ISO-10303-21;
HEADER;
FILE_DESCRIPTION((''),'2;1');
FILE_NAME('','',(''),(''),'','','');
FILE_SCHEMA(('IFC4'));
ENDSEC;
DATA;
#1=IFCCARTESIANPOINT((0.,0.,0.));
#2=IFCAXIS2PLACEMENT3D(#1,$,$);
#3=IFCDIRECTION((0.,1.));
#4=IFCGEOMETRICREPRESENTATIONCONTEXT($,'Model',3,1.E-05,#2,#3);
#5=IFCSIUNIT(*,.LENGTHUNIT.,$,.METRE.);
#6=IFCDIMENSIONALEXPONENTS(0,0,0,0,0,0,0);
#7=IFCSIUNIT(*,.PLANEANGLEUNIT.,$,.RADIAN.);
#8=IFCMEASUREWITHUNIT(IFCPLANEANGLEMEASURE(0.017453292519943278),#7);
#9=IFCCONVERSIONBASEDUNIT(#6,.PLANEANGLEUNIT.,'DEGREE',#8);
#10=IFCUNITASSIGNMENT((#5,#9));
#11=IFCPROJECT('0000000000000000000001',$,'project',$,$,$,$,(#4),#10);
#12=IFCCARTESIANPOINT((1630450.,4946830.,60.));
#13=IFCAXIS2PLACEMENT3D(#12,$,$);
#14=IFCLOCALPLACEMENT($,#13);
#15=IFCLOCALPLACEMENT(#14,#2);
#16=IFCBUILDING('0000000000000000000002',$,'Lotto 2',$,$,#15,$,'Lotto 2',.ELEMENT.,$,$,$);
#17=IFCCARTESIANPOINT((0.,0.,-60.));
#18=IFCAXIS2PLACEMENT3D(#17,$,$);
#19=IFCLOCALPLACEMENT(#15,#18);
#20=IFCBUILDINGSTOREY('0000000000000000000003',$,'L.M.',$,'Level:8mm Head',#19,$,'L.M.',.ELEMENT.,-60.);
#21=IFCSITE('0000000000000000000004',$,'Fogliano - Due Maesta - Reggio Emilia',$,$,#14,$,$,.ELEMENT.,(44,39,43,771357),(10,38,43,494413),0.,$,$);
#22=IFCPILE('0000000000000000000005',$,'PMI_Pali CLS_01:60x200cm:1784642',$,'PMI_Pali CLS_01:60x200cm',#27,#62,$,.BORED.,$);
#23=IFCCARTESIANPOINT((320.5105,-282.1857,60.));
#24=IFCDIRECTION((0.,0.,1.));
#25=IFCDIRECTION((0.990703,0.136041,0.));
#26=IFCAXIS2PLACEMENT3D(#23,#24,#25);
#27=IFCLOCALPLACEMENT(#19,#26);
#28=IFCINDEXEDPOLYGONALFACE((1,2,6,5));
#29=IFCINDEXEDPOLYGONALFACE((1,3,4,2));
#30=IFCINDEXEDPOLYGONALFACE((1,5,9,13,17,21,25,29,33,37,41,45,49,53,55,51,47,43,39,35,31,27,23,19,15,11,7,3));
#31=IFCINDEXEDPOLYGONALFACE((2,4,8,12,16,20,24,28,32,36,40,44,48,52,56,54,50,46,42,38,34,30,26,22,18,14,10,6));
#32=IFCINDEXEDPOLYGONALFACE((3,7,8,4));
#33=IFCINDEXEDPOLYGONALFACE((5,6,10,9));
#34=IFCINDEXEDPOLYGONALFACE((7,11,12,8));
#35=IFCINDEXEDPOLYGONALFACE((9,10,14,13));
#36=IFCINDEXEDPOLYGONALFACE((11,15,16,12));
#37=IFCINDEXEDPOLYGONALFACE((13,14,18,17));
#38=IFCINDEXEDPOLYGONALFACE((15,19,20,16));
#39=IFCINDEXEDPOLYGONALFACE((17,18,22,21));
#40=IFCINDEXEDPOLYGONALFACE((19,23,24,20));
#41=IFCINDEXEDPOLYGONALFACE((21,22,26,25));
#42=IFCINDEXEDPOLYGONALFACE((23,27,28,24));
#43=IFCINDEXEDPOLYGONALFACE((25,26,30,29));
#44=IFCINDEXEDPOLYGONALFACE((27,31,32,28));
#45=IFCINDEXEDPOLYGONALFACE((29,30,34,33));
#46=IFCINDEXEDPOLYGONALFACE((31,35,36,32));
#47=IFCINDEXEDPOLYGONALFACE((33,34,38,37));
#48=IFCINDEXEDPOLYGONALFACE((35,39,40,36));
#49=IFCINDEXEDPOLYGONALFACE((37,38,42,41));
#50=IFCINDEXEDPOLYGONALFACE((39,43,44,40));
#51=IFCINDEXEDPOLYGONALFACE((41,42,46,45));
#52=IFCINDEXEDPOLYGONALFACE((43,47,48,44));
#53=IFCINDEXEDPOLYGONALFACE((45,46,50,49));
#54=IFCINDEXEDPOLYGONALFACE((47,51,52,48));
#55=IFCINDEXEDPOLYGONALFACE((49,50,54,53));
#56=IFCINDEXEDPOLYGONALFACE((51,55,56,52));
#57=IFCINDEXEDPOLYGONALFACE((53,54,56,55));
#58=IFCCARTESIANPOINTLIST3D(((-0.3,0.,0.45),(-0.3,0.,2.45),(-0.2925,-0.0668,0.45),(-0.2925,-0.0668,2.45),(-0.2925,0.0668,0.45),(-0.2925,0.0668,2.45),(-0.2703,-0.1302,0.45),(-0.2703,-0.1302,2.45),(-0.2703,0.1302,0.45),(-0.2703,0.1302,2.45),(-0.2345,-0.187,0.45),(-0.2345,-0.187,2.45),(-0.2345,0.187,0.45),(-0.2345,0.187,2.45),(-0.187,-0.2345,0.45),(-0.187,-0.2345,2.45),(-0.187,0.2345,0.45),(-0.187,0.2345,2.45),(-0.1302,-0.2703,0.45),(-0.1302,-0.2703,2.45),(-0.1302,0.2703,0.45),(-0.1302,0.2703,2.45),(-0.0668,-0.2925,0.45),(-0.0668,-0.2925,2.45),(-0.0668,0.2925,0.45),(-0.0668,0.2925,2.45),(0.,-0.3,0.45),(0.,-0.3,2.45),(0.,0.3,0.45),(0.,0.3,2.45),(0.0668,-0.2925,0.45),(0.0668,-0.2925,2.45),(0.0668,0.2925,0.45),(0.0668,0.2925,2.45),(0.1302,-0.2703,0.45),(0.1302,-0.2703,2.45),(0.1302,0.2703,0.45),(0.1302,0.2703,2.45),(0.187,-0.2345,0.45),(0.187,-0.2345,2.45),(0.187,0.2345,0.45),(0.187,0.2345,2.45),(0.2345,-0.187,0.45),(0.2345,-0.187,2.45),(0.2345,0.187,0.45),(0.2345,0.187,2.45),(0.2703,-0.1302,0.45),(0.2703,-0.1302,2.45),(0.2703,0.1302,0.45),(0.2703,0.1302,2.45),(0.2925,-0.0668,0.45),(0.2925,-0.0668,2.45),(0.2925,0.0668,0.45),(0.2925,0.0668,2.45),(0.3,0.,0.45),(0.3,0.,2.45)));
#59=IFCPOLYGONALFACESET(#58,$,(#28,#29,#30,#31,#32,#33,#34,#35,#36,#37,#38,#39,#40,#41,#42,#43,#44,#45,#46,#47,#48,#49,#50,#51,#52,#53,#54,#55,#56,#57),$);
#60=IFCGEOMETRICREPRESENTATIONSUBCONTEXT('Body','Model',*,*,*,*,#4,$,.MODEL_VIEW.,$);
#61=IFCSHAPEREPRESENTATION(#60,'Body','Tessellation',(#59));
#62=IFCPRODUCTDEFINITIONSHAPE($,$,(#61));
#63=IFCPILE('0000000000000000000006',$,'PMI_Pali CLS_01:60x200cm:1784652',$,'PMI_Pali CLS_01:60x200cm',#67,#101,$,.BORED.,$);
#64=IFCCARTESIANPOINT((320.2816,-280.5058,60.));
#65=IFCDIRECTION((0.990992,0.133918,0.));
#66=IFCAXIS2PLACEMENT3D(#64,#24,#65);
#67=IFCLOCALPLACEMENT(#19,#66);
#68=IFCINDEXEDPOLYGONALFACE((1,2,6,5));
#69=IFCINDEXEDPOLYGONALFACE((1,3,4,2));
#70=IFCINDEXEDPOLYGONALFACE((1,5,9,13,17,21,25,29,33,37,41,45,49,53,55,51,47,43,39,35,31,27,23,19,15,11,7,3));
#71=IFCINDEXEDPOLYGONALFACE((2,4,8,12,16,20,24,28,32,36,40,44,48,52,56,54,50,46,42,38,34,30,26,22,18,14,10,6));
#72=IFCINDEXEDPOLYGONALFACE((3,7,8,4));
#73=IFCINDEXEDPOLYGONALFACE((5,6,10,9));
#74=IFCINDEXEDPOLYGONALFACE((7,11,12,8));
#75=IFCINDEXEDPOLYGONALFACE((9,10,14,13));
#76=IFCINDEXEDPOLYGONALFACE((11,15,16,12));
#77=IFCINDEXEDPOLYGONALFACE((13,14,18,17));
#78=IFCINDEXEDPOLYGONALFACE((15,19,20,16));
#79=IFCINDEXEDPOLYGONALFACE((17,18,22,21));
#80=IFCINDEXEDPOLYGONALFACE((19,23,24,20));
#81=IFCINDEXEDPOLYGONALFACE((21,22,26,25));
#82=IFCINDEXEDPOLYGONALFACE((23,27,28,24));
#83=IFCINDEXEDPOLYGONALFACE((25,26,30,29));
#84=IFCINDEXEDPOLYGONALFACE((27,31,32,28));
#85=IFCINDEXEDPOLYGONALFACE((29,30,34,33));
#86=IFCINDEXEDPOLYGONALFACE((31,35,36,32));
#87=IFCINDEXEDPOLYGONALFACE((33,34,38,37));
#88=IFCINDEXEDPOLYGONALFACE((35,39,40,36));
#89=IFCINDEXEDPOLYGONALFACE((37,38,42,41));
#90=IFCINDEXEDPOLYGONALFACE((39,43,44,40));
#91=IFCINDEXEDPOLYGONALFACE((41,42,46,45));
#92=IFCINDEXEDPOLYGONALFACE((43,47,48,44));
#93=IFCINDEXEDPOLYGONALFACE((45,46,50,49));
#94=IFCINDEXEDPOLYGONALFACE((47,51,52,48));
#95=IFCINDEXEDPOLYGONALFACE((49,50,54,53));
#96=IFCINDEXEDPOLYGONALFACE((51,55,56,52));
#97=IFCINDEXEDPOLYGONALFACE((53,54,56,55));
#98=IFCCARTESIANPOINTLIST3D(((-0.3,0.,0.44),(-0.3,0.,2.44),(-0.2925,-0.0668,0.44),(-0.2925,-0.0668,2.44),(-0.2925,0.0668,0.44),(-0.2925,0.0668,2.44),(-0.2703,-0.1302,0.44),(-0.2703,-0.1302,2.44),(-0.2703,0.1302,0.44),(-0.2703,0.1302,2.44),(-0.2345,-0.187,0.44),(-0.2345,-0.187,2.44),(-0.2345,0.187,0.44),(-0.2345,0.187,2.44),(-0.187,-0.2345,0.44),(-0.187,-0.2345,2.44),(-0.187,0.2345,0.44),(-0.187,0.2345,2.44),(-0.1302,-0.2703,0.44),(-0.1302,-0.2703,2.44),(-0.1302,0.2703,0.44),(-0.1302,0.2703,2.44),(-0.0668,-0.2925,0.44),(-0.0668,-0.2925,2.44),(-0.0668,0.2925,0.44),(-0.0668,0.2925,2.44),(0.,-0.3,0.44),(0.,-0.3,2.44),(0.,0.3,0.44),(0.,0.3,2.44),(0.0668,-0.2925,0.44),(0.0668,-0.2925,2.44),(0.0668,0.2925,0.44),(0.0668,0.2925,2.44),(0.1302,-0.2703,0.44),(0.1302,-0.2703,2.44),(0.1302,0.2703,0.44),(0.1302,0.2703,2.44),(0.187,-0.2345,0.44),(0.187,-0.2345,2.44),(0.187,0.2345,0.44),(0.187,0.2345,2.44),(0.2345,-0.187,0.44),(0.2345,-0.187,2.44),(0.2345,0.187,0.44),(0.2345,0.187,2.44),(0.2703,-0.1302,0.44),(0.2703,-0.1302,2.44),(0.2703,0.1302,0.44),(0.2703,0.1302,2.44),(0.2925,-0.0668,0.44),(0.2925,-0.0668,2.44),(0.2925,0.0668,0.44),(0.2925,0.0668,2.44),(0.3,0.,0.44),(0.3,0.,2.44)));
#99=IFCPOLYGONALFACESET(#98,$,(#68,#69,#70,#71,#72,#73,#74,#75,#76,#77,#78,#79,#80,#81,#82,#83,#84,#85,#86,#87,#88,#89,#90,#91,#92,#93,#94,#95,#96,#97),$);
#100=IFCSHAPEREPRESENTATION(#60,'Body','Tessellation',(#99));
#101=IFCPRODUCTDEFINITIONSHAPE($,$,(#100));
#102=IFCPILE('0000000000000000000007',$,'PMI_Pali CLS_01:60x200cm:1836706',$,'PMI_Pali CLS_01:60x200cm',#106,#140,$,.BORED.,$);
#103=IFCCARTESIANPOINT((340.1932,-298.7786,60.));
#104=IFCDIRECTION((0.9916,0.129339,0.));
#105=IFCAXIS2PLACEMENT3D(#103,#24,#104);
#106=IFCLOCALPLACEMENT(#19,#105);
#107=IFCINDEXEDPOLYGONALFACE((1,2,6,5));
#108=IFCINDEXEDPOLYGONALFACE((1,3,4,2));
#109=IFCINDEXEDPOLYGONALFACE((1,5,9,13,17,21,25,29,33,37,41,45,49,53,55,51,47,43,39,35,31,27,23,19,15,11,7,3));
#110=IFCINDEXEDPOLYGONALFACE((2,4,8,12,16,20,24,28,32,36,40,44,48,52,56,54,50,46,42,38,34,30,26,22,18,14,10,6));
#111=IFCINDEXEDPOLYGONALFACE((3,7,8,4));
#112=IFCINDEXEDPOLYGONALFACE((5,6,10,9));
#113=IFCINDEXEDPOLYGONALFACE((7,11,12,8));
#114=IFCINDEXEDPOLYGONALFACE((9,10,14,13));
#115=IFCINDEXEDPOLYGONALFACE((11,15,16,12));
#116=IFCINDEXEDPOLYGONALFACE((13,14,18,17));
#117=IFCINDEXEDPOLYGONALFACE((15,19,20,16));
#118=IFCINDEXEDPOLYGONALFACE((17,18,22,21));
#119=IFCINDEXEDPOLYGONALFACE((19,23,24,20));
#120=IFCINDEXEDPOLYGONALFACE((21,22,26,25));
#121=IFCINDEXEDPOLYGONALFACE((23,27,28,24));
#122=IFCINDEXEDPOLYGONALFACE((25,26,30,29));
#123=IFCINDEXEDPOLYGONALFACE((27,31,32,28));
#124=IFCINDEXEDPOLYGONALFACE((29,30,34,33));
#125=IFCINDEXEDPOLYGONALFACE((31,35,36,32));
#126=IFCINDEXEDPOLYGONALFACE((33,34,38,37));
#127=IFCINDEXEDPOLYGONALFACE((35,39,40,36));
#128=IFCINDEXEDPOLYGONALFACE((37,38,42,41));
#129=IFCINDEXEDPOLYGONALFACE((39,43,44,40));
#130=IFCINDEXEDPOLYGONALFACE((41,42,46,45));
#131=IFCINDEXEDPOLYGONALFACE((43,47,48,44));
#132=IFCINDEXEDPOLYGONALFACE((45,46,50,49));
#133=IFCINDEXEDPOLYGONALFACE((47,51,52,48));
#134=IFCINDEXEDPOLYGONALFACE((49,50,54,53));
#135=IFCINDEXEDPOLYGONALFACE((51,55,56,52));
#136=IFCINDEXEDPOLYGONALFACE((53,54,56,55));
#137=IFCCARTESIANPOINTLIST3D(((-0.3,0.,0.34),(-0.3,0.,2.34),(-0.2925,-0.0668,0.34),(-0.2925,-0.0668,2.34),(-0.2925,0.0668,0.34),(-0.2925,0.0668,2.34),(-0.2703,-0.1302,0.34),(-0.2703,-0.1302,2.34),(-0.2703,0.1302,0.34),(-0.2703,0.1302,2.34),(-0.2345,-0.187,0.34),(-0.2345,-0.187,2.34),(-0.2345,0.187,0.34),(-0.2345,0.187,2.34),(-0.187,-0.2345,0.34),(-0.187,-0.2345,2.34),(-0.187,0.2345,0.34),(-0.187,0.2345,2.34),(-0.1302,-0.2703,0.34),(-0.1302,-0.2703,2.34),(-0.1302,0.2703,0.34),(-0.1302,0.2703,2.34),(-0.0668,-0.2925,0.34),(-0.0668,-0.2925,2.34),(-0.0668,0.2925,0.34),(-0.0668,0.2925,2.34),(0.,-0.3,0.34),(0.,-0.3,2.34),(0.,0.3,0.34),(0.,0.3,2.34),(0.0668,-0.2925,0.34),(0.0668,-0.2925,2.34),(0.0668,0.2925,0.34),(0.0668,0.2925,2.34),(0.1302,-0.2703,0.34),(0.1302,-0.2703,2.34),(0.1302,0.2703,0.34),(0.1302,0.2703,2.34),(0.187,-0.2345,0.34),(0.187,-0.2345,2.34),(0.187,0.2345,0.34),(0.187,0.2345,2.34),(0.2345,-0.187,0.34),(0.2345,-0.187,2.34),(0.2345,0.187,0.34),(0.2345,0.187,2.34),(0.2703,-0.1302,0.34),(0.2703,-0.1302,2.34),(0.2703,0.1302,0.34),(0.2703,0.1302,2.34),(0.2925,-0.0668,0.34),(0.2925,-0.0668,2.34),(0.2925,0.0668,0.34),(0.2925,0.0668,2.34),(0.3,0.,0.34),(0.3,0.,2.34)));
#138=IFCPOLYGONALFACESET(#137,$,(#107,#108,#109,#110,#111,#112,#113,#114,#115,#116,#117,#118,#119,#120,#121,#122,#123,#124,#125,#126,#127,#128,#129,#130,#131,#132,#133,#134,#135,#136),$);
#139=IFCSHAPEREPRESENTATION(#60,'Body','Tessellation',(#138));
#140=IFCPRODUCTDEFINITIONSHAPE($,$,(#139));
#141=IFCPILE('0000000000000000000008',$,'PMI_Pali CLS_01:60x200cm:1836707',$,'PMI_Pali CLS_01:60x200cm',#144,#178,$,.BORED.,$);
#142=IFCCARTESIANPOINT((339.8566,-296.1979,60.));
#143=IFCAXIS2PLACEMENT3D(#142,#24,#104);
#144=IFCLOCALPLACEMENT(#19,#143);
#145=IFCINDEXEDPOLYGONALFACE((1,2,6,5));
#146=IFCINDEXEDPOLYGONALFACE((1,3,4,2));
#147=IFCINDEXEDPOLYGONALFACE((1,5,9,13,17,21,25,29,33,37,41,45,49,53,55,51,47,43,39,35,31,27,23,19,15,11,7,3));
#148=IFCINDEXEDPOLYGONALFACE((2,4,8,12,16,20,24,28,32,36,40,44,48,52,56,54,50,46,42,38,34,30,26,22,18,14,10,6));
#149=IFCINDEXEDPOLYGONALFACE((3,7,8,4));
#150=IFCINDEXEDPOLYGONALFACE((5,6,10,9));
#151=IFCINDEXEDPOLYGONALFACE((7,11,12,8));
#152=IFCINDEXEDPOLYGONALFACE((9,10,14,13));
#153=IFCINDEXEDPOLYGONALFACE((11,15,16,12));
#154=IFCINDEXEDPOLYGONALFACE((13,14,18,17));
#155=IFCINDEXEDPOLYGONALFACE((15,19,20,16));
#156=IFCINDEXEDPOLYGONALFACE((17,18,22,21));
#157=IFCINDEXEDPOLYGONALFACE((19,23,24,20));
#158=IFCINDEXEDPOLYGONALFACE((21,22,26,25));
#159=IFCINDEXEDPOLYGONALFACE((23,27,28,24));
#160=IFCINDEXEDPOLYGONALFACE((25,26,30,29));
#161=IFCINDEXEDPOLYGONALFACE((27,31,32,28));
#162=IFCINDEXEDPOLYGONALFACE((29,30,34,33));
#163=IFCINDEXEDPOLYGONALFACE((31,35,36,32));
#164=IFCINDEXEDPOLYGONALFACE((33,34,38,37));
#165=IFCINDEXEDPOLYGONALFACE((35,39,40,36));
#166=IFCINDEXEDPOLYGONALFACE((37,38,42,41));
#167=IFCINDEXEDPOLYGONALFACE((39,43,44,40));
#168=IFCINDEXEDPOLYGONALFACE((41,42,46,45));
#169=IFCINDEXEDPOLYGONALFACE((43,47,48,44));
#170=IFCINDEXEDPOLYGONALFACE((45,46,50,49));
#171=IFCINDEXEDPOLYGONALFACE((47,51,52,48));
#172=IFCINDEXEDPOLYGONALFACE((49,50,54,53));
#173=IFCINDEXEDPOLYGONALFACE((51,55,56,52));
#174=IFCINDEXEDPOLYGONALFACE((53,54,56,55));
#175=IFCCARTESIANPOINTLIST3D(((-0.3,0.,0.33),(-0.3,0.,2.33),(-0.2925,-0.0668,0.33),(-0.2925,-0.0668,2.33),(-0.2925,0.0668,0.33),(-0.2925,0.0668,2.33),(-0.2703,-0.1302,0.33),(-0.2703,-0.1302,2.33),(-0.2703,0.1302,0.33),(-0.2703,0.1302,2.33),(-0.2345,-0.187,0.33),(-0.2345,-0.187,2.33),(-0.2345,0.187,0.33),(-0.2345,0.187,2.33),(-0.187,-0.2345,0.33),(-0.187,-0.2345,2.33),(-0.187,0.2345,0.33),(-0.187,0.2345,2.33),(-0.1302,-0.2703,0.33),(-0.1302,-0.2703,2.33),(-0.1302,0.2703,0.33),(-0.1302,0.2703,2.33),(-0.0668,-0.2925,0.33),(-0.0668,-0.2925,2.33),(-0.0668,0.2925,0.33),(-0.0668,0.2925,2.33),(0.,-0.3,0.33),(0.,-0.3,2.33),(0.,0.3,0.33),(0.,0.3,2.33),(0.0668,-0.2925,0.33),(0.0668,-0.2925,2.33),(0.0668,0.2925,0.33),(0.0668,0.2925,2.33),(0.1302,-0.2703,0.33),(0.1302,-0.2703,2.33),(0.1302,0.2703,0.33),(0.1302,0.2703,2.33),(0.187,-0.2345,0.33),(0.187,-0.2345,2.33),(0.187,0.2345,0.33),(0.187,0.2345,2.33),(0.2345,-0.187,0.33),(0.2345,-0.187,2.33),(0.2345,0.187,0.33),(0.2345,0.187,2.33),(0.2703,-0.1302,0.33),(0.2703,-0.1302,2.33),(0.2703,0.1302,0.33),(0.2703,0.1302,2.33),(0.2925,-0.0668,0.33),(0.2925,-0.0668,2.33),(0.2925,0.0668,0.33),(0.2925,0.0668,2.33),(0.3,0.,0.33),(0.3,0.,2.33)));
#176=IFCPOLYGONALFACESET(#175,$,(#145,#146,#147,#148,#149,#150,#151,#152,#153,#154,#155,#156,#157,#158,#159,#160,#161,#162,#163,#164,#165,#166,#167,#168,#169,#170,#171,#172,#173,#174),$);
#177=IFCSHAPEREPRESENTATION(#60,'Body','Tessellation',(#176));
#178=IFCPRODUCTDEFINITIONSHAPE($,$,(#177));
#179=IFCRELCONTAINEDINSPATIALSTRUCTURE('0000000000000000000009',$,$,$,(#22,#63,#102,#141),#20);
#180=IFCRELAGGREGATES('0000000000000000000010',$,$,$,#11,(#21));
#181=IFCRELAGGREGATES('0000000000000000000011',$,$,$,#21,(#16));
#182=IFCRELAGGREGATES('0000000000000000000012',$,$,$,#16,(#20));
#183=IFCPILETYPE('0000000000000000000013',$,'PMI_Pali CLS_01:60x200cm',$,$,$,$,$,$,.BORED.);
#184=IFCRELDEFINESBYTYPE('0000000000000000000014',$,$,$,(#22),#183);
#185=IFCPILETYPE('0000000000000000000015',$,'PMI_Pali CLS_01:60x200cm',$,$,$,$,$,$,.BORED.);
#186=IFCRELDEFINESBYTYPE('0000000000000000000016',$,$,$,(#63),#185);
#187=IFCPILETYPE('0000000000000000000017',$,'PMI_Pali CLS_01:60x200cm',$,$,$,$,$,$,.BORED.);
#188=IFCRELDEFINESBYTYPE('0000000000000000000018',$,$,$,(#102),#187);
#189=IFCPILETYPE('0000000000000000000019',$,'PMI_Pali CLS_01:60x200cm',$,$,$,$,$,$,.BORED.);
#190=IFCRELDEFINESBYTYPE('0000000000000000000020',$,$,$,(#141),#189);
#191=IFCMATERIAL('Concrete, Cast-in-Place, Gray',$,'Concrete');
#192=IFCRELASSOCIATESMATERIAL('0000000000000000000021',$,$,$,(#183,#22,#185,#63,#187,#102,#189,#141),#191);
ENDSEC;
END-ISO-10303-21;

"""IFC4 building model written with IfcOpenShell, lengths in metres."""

from ifc_helpers import new_model, entity, si_unit, converted_unit, direction, frame, origin, place, context, subcontext, project, spatial, arc, indexed_curve, outline, extrude, source, transform, mapped, material, type_object, type_shapes, element, save


model = new_model("IFC4")

# Units and contexts
model_context = context("Model", 3, precision=1e-05, world=origin(), true_north=direction((0.0, 1.0)))
body_context = subcontext(model_context, "Body", "Model", "MODEL_VIEW")
ifc_project = project(units=[si_unit("LENGTHUNIT", "METRE"), converted_unit("PLANEANGLEUNIT", "DEGREE", entity("IfcPlaneAngleMeasure", 0.017453292519943278), si_unit("PLANEANGLEUNIT", "RADIAN"), dimensions=[0, 0, 0, 0, 0, 0, 0])], contexts=[model_context])

# Site, building, storey
site_placement = place(None, frame((1630450.0, 4946830.0, 60.0)))
site = spatial("IfcSite", under=ifc_project, at=site_placement, Name="Fogliano - Due Maesta - Reggio Emilia", CompositionType="ELEMENT", RefLatitude=(44, 39, 43, 771357), RefLongitude=(10, 38, 43, 494413), RefElevation=0.0)
building_placement = place(site_placement, origin())
building = spatial("IfcBuilding", under=site, at=building_placement, Name="Lotto 2", LongName="Lotto 2", CompositionType="ELEMENT")
storey_placement = place(building_placement, frame((0.0, 0.0, -60.0)))
storey = spatial("IfcBuildingStorey", under=building, at=storey_placement, Name="L.M.", ObjectType="Level:8mm Head", LongName="L.M.", CompositionType="ELEMENT", Elevation=-60.0)

# Piles
ifc_material_1 = material(Name="Concrete, Cast-in-Place, Gray", Category="Concrete")
pile_type_1 = type_object("IfcPileType", Name="PMI_Pali CLS_01:60x200cm", PredefinedType="BORED", material=ifc_material_1)
shared_shape_1 = source(origin(), body_context, "Body", "SweptSolid", [
    extrude(outline(indexed_curve([(-0.3, 0.0), (0.0, -0.3), (0.3, 0.0), (0.0, 0.3)], segments=[arc(1, 2, 3), arc(3, 4, 1)], self_intersect=False)), frame((0.0, 0.0, 0.45)), (0.0, 0.0, 1.0), 2.0),
])
type_shapes(pile_type_1, [shared_shape_1])
pile_1_placement = place(storey_placement, frame((320.5105, -282.1857, 60.0), z_axis=(0.0, 0.0, 1.0), x_axis=(0.990703, 0.136041, 0.0)))
element("IfcPile", 1, at=pile_1_placement, inside=storey, type_object=pile_type_1, material=ifc_material_1, Name="PMI_Pali CLS_01:60x200cm:1784642", ObjectType="PMI_Pali CLS_01:60x200cm", PredefinedType="BORED", context=body_context, shape_type="MappedRepresentation", body=[
    mapped(shared_shape_1, transform((0.0, 0.0, 0.0), scale=1.0)),
])
pile_type_2 = type_object("IfcPileType", Name="PMI_Pali CLS_01:60x200cm", PredefinedType="BORED", material=ifc_material_1)
shared_shape_2 = source(origin(), body_context, "Body", "SweptSolid", [
    extrude(outline(indexed_curve([(-0.3, 0.0), (0.0, -0.3), (0.3, 0.0), (0.0, 0.3)], segments=[arc(1, 2, 3), arc(3, 4, 1)], self_intersect=False)), frame((0.0, 0.0, 0.44)), (0.0, 0.0, 1.0), 2.0),
])
type_shapes(pile_type_2, [shared_shape_2])
pile_2_placement = place(storey_placement, frame((320.2816, -280.5058, 60.0), z_axis=(0.0, 0.0, 1.0), x_axis=(0.990992, 0.133918, 0.0)))
element("IfcPile", 2, at=pile_2_placement, inside=storey, type_object=pile_type_2, material=ifc_material_1, Name="PMI_Pali CLS_01:60x200cm:1784652", ObjectType="PMI_Pali CLS_01:60x200cm", PredefinedType="BORED", context=body_context, shape_type="MappedRepresentation", body=[
    mapped(shared_shape_2, transform((0.0, 0.0, 0.0), scale=1.0)),
])
pile_type_3 = type_object("IfcPileType", Name="PMI_Pali CLS_01:60x200cm", PredefinedType="BORED", material=ifc_material_1)
shared_shape_3 = source(origin(), body_context, "Body", "SweptSolid", [
    extrude(outline(indexed_curve([(-0.3, 0.0), (0.0, -0.3), (0.3, 0.0), (0.0, 0.3)], segments=[arc(1, 2, 3), arc(3, 4, 1)], self_intersect=False)), frame((0.0, 0.0, 0.34)), (0.0, 0.0, 1.0), 2.0),
])
type_shapes(pile_type_3, [shared_shape_3])
pile_3_placement = place(storey_placement, frame((340.1932, -298.7786, 60.0), z_axis=(0.0, 0.0, 1.0), x_axis=(0.9916, 0.129339, 0.0)))
element("IfcPile", 3, at=pile_3_placement, inside=storey, type_object=pile_type_3, material=ifc_material_1, Name="PMI_Pali CLS_01:60x200cm:1836706", ObjectType="PMI_Pali CLS_01:60x200cm", PredefinedType="BORED", context=body_context, shape_type="MappedRepresentation", body=[
    mapped(shared_shape_3, transform((0.0, 0.0, 0.0), scale=1.0)),
])
pile_type_4 = type_object("IfcPileType", Name="PMI_Pali CLS_01:60x200cm", PredefinedType="BORED", material=ifc_material_1)
shared_shape_4 = source(origin(), body_context, "Body", "SweptSolid", [
    extrude(outline(indexed_curve([(-0.3, 0.0), (0.0, -0.3), (0.3, 0.0), (0.0, 0.3)], segments=[arc(1, 2, 3), arc(3, 4, 1)], self_intersect=False)), frame((0.0, 0.0, 0.33)), (0.0, 0.0, 1.0), 2.0),
])
type_shapes(pile_type_4, [shared_shape_4])
pile_4_placement = place(storey_placement, frame((339.8566, -296.1979, 60.0), z_axis=(0.0, 0.0, 1.0), x_axis=(0.9916, 0.129339, 0.0)))
element("IfcPile", 4, at=pile_4_placement, inside=storey, type_object=pile_type_4, material=ifc_material_1, Name="PMI_Pali CLS_01:60x200cm:1836707", ObjectType="PMI_Pali CLS_01:60x200cm", PredefinedType="BORED", context=body_context, shape_type="MappedRepresentation", body=[
    mapped(shared_shape_4, transform((0.0, 0.0, 0.0), scale=1.0)),
])

save(model, "model.ifc")
